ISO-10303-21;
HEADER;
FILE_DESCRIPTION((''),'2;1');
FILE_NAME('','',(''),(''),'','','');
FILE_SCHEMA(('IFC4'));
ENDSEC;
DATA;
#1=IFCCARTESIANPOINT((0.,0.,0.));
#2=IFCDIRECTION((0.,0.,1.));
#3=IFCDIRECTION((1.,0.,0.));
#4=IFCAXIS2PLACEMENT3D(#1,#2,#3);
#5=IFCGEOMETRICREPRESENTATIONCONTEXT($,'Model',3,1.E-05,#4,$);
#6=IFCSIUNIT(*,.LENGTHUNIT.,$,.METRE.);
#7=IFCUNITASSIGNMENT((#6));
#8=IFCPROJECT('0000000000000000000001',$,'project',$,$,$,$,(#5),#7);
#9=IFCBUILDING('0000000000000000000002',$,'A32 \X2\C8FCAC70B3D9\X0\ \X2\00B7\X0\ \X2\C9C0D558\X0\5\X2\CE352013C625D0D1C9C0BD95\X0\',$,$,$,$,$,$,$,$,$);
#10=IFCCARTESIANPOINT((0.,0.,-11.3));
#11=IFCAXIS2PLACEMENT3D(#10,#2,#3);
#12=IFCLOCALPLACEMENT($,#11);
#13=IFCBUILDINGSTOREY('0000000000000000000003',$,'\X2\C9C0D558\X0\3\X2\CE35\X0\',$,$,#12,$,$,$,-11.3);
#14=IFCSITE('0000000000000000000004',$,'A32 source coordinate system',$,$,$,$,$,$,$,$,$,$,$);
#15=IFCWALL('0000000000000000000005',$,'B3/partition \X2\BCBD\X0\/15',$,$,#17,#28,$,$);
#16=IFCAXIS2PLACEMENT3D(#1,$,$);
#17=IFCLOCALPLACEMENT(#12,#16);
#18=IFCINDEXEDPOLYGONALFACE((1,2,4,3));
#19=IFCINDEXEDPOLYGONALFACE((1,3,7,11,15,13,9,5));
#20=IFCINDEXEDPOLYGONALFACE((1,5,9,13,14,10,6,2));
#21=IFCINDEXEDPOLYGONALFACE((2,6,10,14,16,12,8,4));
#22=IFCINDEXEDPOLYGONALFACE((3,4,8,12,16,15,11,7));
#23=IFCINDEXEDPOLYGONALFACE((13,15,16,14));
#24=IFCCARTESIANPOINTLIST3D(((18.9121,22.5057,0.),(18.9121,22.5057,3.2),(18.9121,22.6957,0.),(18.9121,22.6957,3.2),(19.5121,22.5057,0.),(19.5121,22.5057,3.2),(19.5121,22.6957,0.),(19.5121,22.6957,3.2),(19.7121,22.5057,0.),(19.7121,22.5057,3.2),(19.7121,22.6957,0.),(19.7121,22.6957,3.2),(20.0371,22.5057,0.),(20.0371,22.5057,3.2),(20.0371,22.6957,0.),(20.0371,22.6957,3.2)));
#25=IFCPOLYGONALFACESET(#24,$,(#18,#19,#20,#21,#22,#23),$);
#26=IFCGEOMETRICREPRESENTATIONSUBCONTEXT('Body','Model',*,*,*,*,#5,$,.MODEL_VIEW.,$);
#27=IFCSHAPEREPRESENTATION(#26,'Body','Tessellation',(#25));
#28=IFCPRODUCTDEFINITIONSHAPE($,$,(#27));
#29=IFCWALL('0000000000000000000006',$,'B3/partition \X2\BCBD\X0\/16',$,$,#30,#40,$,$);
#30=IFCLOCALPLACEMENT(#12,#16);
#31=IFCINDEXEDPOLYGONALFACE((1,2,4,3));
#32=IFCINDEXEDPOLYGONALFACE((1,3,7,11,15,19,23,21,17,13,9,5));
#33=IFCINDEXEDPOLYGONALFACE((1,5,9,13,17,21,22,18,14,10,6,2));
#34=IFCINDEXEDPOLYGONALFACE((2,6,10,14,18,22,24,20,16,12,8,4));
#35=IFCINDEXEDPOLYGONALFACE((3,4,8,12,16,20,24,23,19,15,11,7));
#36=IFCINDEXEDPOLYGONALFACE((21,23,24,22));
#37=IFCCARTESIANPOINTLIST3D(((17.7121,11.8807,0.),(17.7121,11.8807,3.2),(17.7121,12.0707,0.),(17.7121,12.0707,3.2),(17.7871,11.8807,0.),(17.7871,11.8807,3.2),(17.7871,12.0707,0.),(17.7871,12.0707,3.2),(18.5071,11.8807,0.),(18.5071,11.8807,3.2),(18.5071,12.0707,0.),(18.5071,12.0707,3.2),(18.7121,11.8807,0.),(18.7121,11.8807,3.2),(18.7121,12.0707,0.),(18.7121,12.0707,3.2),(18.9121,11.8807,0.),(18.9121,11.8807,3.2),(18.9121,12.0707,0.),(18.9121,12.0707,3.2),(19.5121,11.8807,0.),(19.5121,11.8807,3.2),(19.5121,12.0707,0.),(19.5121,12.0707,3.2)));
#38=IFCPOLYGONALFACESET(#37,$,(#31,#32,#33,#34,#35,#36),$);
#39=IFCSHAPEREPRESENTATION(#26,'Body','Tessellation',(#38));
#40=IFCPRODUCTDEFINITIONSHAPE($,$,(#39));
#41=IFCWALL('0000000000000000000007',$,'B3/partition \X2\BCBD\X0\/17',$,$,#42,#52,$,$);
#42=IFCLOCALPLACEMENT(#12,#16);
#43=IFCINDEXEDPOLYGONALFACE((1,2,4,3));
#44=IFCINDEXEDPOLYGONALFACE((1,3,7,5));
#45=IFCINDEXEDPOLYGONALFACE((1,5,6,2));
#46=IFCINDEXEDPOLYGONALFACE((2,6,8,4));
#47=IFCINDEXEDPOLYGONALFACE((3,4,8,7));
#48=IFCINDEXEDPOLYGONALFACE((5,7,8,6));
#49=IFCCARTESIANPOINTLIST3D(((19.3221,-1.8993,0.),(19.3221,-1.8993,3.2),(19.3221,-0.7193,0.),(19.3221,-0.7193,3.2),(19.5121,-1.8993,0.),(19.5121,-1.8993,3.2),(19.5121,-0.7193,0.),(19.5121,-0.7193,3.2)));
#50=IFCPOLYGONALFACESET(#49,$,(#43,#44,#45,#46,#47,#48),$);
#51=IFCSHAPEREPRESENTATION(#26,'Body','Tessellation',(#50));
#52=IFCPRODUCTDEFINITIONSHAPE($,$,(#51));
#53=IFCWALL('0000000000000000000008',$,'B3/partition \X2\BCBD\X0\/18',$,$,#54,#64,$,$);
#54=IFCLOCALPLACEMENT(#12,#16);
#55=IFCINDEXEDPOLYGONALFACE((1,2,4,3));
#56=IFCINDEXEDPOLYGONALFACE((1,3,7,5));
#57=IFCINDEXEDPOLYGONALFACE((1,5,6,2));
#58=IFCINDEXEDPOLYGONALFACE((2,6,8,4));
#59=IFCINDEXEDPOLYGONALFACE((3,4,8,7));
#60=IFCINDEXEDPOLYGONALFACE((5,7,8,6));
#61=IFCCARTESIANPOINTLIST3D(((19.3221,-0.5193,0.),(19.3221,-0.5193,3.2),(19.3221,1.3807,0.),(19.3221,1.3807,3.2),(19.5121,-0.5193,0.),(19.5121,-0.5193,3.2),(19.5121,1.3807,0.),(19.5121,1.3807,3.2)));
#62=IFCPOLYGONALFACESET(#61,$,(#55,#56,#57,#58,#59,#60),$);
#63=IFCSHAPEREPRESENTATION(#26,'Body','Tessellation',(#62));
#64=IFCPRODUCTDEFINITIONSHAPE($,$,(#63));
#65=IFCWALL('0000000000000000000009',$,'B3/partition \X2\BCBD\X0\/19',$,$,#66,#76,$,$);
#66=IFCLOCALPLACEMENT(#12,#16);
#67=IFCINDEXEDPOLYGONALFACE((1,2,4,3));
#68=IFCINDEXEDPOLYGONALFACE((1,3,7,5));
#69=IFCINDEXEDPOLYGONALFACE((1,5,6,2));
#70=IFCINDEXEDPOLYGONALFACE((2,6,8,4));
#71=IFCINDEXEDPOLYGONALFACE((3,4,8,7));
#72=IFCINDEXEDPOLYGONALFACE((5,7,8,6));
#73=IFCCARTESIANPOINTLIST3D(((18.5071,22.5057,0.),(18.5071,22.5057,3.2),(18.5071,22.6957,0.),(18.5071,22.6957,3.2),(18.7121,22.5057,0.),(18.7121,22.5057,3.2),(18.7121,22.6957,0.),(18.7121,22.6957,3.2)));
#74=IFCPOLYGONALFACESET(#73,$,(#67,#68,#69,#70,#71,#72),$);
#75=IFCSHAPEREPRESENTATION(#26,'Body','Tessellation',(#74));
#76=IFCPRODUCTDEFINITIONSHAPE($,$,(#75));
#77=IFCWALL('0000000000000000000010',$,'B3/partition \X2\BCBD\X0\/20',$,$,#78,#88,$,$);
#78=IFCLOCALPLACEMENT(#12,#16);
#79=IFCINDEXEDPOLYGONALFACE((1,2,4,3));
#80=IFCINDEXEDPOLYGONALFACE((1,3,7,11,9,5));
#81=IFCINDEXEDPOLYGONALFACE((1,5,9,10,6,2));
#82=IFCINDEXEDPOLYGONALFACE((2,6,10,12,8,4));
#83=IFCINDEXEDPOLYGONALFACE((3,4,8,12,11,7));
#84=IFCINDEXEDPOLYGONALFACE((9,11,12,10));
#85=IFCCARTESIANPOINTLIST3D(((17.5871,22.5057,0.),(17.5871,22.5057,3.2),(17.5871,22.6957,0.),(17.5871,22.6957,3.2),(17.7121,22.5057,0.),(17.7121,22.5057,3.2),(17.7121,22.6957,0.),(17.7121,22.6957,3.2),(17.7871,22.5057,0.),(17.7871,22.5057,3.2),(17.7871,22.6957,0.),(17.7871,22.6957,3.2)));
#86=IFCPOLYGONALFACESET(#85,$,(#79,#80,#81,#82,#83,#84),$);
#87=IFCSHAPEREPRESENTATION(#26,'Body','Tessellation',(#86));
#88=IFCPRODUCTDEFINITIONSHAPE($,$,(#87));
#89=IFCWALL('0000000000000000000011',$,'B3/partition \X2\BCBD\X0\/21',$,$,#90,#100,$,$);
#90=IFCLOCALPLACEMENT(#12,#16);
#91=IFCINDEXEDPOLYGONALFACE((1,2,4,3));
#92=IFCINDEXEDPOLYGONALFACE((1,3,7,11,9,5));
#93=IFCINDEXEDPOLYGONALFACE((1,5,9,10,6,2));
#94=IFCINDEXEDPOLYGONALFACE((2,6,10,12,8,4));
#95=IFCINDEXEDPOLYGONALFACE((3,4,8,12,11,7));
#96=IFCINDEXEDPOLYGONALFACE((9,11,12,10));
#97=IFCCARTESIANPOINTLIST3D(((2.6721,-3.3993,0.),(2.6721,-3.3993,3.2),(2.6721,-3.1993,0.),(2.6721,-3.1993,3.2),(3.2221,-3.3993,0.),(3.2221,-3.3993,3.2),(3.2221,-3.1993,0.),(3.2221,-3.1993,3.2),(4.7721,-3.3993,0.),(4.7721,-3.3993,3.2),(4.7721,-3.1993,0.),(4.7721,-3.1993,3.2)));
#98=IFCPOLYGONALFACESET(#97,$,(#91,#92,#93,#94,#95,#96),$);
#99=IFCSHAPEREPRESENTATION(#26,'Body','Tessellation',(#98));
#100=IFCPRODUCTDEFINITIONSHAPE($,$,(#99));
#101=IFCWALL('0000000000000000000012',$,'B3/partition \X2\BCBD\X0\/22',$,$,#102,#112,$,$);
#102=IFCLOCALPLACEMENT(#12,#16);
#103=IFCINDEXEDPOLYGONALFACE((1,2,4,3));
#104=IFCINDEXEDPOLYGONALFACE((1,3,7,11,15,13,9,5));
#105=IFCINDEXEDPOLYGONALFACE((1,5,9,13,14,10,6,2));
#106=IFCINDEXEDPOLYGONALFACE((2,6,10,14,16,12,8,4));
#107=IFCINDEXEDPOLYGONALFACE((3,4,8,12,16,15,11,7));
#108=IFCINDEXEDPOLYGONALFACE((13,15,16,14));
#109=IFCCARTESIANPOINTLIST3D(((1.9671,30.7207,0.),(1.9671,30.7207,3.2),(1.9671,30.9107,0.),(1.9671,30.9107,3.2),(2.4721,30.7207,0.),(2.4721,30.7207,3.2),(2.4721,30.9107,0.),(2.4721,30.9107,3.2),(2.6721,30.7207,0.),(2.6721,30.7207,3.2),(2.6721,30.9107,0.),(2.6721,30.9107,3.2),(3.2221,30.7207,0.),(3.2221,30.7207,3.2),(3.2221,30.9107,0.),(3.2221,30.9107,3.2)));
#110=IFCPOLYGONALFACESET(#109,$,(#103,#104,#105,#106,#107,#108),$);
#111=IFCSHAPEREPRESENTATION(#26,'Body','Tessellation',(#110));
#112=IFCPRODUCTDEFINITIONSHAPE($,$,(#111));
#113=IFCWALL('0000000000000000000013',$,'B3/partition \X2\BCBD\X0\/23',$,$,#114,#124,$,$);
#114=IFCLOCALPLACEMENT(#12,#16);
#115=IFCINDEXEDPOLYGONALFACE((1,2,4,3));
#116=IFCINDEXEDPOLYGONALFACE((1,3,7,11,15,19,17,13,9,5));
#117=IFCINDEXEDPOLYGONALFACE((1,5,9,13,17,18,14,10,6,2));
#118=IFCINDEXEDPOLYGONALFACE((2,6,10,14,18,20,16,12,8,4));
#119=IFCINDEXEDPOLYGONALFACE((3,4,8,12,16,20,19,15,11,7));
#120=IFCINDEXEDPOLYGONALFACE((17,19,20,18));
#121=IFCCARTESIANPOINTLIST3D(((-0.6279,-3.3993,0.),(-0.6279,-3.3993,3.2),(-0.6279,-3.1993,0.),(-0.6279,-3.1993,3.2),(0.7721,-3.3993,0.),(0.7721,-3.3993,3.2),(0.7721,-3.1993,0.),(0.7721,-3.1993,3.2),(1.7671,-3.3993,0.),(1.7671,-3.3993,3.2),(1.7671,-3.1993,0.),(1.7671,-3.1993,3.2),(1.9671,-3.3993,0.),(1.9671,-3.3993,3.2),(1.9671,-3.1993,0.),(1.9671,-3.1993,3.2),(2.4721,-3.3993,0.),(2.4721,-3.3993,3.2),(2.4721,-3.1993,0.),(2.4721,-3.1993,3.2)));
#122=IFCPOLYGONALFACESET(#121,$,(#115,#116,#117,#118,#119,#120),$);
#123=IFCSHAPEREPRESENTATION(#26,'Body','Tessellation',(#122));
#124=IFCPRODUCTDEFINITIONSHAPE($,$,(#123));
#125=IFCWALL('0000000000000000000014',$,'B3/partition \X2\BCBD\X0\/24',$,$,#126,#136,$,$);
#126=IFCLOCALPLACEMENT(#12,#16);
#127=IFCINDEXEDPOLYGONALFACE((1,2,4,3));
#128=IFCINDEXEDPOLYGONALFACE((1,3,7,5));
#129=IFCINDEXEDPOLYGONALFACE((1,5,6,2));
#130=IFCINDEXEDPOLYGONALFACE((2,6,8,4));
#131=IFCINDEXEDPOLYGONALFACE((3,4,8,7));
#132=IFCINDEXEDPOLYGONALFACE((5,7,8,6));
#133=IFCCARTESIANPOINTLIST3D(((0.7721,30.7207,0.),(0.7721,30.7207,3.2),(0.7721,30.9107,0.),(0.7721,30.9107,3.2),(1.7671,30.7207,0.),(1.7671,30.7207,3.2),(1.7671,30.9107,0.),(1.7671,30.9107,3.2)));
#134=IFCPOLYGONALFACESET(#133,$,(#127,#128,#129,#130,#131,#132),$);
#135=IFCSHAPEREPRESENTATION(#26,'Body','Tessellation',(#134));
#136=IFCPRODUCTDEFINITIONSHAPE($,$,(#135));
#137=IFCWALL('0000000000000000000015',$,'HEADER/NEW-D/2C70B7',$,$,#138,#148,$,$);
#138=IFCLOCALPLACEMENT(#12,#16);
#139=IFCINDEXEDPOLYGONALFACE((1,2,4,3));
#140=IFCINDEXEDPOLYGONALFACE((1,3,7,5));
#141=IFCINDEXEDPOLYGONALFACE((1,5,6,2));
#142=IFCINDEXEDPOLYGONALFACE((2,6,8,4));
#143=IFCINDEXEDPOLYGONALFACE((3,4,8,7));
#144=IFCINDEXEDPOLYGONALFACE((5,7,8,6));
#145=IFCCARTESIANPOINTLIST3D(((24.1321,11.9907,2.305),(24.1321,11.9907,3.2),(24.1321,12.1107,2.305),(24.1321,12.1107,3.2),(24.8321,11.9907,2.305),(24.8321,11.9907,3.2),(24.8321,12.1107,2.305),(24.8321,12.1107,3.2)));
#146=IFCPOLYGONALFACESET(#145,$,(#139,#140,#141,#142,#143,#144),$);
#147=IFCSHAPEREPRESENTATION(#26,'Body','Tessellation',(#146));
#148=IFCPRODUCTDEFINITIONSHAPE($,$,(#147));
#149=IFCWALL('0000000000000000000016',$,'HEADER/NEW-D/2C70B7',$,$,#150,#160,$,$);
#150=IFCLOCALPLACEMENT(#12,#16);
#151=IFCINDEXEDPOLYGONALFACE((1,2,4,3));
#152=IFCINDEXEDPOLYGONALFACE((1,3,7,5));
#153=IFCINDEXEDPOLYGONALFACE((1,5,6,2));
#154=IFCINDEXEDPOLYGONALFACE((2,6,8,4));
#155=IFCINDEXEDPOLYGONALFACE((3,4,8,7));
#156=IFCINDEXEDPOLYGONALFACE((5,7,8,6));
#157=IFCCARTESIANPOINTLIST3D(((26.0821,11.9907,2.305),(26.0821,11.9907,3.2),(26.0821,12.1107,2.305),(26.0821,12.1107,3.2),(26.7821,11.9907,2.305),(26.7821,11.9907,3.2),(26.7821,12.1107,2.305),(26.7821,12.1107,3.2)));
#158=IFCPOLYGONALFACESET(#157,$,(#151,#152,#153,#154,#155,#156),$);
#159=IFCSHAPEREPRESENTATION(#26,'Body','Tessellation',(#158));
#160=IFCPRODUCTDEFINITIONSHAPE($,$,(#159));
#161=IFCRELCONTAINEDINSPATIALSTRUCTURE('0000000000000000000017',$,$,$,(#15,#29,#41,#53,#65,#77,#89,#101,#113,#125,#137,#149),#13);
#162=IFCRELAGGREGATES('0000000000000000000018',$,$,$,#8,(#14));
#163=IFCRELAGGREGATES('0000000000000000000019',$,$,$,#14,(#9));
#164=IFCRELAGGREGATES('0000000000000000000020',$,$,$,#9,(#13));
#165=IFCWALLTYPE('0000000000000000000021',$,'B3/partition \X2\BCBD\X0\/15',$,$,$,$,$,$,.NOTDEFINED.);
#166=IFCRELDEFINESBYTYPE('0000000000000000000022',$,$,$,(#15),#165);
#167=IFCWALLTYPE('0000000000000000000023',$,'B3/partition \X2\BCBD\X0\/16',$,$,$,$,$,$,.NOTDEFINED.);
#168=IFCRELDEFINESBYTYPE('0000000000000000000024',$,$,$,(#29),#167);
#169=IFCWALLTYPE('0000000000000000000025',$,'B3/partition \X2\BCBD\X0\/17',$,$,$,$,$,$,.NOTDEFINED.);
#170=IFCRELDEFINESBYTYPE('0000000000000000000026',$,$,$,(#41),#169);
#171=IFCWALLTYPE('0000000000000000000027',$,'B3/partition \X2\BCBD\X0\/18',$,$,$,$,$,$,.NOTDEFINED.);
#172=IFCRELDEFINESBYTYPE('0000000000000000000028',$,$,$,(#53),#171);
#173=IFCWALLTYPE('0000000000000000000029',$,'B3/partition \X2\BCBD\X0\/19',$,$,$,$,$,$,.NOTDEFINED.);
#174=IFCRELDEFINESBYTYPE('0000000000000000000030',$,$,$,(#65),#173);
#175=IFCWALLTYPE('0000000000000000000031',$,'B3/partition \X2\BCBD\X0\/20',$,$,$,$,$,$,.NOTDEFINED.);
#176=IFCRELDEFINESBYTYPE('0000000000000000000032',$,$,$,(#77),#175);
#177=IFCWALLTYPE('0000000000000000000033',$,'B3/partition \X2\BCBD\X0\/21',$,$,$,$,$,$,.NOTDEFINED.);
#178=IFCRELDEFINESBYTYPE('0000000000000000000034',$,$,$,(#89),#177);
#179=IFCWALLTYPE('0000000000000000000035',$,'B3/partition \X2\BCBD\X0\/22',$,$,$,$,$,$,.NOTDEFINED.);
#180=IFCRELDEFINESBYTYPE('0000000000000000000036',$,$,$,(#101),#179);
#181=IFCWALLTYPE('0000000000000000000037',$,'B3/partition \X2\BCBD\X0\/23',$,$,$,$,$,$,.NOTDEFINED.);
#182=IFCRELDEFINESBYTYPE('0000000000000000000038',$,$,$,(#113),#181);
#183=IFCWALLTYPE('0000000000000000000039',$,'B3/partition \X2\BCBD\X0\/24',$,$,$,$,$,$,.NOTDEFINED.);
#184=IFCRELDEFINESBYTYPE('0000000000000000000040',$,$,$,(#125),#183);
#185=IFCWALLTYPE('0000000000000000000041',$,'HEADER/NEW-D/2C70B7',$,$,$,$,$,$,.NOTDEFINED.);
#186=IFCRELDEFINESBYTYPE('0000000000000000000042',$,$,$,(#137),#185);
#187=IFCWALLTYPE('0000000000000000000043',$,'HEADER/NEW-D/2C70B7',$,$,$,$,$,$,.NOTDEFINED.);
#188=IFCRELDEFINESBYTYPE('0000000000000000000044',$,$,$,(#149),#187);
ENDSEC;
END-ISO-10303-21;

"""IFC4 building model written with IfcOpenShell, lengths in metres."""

from ifc_helpers import new_model, si_unit, frame, origin, origin_with_axes, place, context, subcontext, project, spatial, polyline, outline, extrude, source, transform, mapped, type_object, type_shapes, element, save


model = new_model("IFC4")

# Units and contexts
model_context = context("Model", 3, precision=1e-05, world=origin_with_axes())
body_context = subcontext(model_context, "Body", "Model", "MODEL_VIEW")
ifc_project = project(units=[si_unit("LENGTHUNIT", "METRE")], contexts=[model_context])

# Site, building, storey
site = spatial("IfcSite", under=ifc_project, Name="A32 source coordinate system")
building = spatial("IfcBuilding", under=site, Name="A32 주거동 · 지하5층–옥탑지붕")
storey_placement = place(None, frame((0.0, 0.0, -11.3), z_axis=(0.0, 0.0, 1.0), x_axis=(1.0, 0.0, 0.0)))
storey = spatial("IfcBuildingStorey", under=building, at=storey_placement, Name="지하3층", Elevation=-11.3)

# Walls
wall_type_1 = type_object("IfcWallType", Name="B3/partition 벽/15", PredefinedType="NOTDEFINED")
shared_shape_1 = source(origin(), body_context, "Body", "SweptSolid", [
    extrude(outline(polyline([(19.7121, 22.5057), (19.5121, 22.5057), (18.9121, 22.5057), (18.9121, 22.6957), (19.5121, 22.6957), (19.7121, 22.6957), (20.0371, 22.6957), (20.0371, 22.5057), (19.7121, 22.5057)])), origin(), (0.0, 0.0, 1.0), 3.2),
])
type_shapes(wall_type_1, [shared_shape_1])
wall_1_placement = place(storey_placement, origin_with_axes())
element("IfcWall", 1, at=wall_1_placement, inside=storey, type_object=wall_type_1, Name="B3/partition 벽/15", context=body_context, shape_type="MappedRepresentation", body=[
    mapped(shared_shape_1, transform((0.0, 0.0, 0.0), scale=1.0)),
])
wall_type_2 = type_object("IfcWallType", Name="B3/partition 벽/16", PredefinedType="NOTDEFINED")
shared_shape_2 = source(origin(), body_context, "Body", "SweptSolid", [
    extrude(outline(polyline([(18.9121, 12.0707), (19.5121, 12.0707), (19.5121, 11.8807), (18.9121, 11.8807), (18.7121, 11.8807), (18.5071, 11.8807), (17.7871, 11.8807), (17.7121, 11.8807), (17.7121, 12.0707), (17.7871, 12.0707), (18.5071, 12.0707), (18.7121, 12.0707), (18.9121, 12.0707)])), origin(), (0.0, 0.0, 1.0), 3.2),
])
type_shapes(wall_type_2, [shared_shape_2])
wall_2_placement = place(storey_placement, origin_with_axes())
element("IfcWall", 2, at=wall_2_placement, inside=storey, type_object=wall_type_2, Name="B3/partition 벽/16", context=body_context, shape_type="MappedRepresentation", body=[
    mapped(shared_shape_2, transform((0.0, 0.0, 0.0), scale=1.0)),
])
wall_type_3 = type_object("IfcWallType", Name="B3/partition 벽/17", PredefinedType="NOTDEFINED")
shared_shape_3 = source(origin(), body_context, "Body", "SweptSolid", [
    extrude(outline(polyline([(19.5121, -0.7193), (19.5121, -1.8993), (19.3221, -1.8993), (19.3221, -0.7193), (19.5121, -0.7193)])), origin(), (0.0, 0.0, 1.0), 3.2),
])
type_shapes(wall_type_3, [shared_shape_3])
wall_3_placement = place(storey_placement, origin_with_axes())
element("IfcWall", 3, at=wall_3_placement, inside=storey, type_object=wall_type_3, Name="B3/partition 벽/17", context=body_context, shape_type="MappedRepresentation", body=[
    mapped(shared_shape_3, transform((0.0, 0.0, 0.0), scale=1.0)),
])
wall_type_4 = type_object("IfcWallType", Name="B3/partition 벽/18", PredefinedType="NOTDEFINED")
shared_shape_4 = source(origin(), body_context, "Body", "SweptSolid", [
    extrude(outline(polyline([(19.3221, 1.3807), (19.5121, 1.3807), (19.5121, -0.5193), (19.3221, -0.5193), (19.3221, 1.3807)])), origin(), (0.0, 0.0, 1.0), 3.2),
])
type_shapes(wall_type_4, [shared_shape_4])
wall_4_placement = place(storey_placement, origin_with_axes())
element("IfcWall", 4, at=wall_4_placement, inside=storey, type_object=wall_type_4, Name="B3/partition 벽/18", context=body_context, shape_type="MappedRepresentation", body=[
    mapped(shared_shape_4, transform((0.0, 0.0, 0.0), scale=1.0)),
])
wall_type_5 = type_object("IfcWallType", Name="B3/partition 벽/19", PredefinedType="NOTDEFINED")
shared_shape_5 = source(origin(), body_context, "Body", "SweptSolid", [
    extrude(outline(polyline([(18.5071, 22.6957), (18.7121, 22.6957), (18.7121, 22.5057), (18.5071, 22.5057), (18.5071, 22.6957)])), origin(), (0.0, 0.0, 1.0), 3.2),
])
type_shapes(wall_type_5, [shared_shape_5])
wall_5_placement = place(storey_placement, origin_with_axes())
element("IfcWall", 5, at=wall_5_placement, inside=storey, type_object=wall_type_5, Name="B3/partition 벽/19", context=body_context, shape_type="MappedRepresentation", body=[
    mapped(shared_shape_5, transform((0.0, 0.0, 0.0), scale=1.0)),
])
wall_type_6 = type_object("IfcWallType", Name="B3/partition 벽/20", PredefinedType="NOTDEFINED")
shared_shape_6 = source(origin(), body_context, "Body", "SweptSolid", [
    extrude(outline(polyline([(17.5871, 22.5057), (17.5871, 22.6957), (17.7121, 22.6957), (17.7871, 22.6957), (17.7871, 22.5057), (17.7121, 22.5057), (17.5871, 22.5057)])), origin(), (0.0, 0.0, 1.0), 3.2),
])
type_shapes(wall_type_6, [shared_shape_6])
wall_6_placement = place(storey_placement, origin_with_axes())
element("IfcWall", 6, at=wall_6_placement, inside=storey, type_object=wall_type_6, Name="B3/partition 벽/20", context=body_context, shape_type="MappedRepresentation", body=[
    mapped(shared_shape_6, transform((0.0, 0.0, 0.0), scale=1.0)),
])
wall_type_7 = type_object("IfcWallType", Name="B3/partition 벽/21", PredefinedType="NOTDEFINED")
shared_shape_7 = source(origin(), body_context, "Body", "SweptSolid", [
    extrude(outline(polyline([(2.6721, -3.3993), (2.6721, -3.1993), (3.2221, -3.1993), (4.7721, -3.1993), (4.7721, -3.3993), (3.2221, -3.3993), (2.6721, -3.3993)])), origin(), (0.0, 0.0, 1.0), 3.2),
])
type_shapes(wall_type_7, [shared_shape_7])
wall_7_placement = place(storey_placement, origin_with_axes())
element("IfcWall", 7, at=wall_7_placement, inside=storey, type_object=wall_type_7, Name="B3/partition 벽/21", context=body_context, shape_type="MappedRepresentation", body=[
    mapped(shared_shape_7, transform((0.0, 0.0, 0.0), scale=1.0)),
])
wall_type_8 = type_object("IfcWallType", Name="B3/partition 벽/22", PredefinedType="NOTDEFINED")
shared_shape_8 = source(origin(), body_context, "Body", "SweptSolid", [
    extrude(outline(polyline([(2.6721, 30.7207), (2.4721, 30.7207), (1.9671, 30.7207), (1.9671, 30.9107), (2.4721, 30.9107), (2.6721, 30.9107), (3.2221, 30.9107), (3.2221, 30.7207), (2.6721, 30.7207)])), origin(), (0.0, 0.0, 1.0), 3.2),
])
type_shapes(wall_type_8, [shared_shape_8])
wall_8_placement = place(storey_placement, origin_with_axes())
element("IfcWall", 8, at=wall_8_placement, inside=storey, type_object=wall_type_8, Name="B3/partition 벽/22", context=body_context, shape_type="MappedRepresentation", body=[
    mapped(shared_shape_8, transform((0.0, 0.0, 0.0), scale=1.0)),
])
wall_type_9 = type_object("IfcWallType", Name="B3/partition 벽/23", PredefinedType="NOTDEFINED")
shared_shape_9 = source(origin(), body_context, "Body", "SweptSolid", [
    extrude(outline(polyline([(2.4721, -3.1993), (2.4721, -3.3993), (1.9671, -3.3993), (1.7671, -3.3993), (0.7721, -3.3993), (-0.6279, -3.3993), (-0.6279, -3.1993), (0.7721, -3.1993), (1.7671, -3.1993), (1.9671, -3.1993), (2.4721, -3.1993)])), origin(), (0.0, 0.0, 1.0), 3.2),
])
type_shapes(wall_type_9, [shared_shape_9])
wall_9_placement = place(storey_placement, origin_with_axes())
element("IfcWall", 9, at=wall_9_placement, inside=storey, type_object=wall_type_9, Name="B3/partition 벽/23", context=body_context, shape_type="MappedRepresentation", body=[
    mapped(shared_shape_9, transform((0.0, 0.0, 0.0), scale=1.0)),
])
wall_type_10 = type_object("IfcWallType", Name="B3/partition 벽/24", PredefinedType="NOTDEFINED")
shared_shape_10 = source(origin(), body_context, "Body", "SweptSolid", [
    extrude(outline(polyline([(1.7671, 30.9107), (1.7671, 30.7207), (0.7721, 30.7207), (0.7721, 30.9107), (1.7671, 30.9107)])), origin(), (0.0, 0.0, 1.0), 3.2),
])
type_shapes(wall_type_10, [shared_shape_10])
wall_10_placement = place(storey_placement, origin_with_axes())
element("IfcWall", 10, at=wall_10_placement, inside=storey, type_object=wall_type_10, Name="B3/partition 벽/24", context=body_context, shape_type="MappedRepresentation", body=[
    mapped(shared_shape_10, transform((0.0, 0.0, 0.0), scale=1.0)),
])
wall_type_11 = type_object("IfcWallType", Name="HEADER/NEW-D/2C70B7", PredefinedType="NOTDEFINED")
shared_shape_11 = source(origin(), body_context, "Body", "SweptSolid", [
    extrude(outline(polyline([(24.1321, 11.9907), (24.1321, 12.1107), (24.8321, 12.1107), (24.8321, 11.9907), (24.1321, 11.9907)])), frame((0.0, 0.0, 2.305)), (0.0, 0.0, 1.0), 0.895),
])
type_shapes(wall_type_11, [shared_shape_11])
wall_11_placement = place(storey_placement, origin_with_axes())
element("IfcWall", 11, at=wall_11_placement, inside=storey, type_object=wall_type_11, Name="HEADER/NEW-D/2C70B7", context=body_context, shape_type="MappedRepresentation", body=[
    mapped(shared_shape_11, transform((0.0, 0.0, 0.0), scale=1.0)),
])
wall_type_12 = type_object("IfcWallType", Name="HEADER/NEW-D/2C70B7", PredefinedType="NOTDEFINED")
shared_shape_12 = source(origin(), body_context, "Body", "SweptSolid", [
    extrude(outline(polyline([(26.0821, 11.9907), (26.0821, 12.1107), (26.7821, 12.1107), (26.7821, 11.9907), (26.0821, 11.9907)])), frame((0.0, 0.0, 2.305)), (0.0, 0.0, 1.0), 0.895),
])
type_shapes(wall_type_12, [shared_shape_12])
wall_12_placement = place(storey_placement, origin_with_axes())
element("IfcWall", 12, at=wall_12_placement, inside=storey, type_object=wall_type_12, Name="HEADER/NEW-D/2C70B7", context=body_context, shape_type="MappedRepresentation", body=[
    mapped(shared_shape_12, transform((0.0, 0.0, 0.0), scale=1.0)),
])

save(model, "model.ifc")
